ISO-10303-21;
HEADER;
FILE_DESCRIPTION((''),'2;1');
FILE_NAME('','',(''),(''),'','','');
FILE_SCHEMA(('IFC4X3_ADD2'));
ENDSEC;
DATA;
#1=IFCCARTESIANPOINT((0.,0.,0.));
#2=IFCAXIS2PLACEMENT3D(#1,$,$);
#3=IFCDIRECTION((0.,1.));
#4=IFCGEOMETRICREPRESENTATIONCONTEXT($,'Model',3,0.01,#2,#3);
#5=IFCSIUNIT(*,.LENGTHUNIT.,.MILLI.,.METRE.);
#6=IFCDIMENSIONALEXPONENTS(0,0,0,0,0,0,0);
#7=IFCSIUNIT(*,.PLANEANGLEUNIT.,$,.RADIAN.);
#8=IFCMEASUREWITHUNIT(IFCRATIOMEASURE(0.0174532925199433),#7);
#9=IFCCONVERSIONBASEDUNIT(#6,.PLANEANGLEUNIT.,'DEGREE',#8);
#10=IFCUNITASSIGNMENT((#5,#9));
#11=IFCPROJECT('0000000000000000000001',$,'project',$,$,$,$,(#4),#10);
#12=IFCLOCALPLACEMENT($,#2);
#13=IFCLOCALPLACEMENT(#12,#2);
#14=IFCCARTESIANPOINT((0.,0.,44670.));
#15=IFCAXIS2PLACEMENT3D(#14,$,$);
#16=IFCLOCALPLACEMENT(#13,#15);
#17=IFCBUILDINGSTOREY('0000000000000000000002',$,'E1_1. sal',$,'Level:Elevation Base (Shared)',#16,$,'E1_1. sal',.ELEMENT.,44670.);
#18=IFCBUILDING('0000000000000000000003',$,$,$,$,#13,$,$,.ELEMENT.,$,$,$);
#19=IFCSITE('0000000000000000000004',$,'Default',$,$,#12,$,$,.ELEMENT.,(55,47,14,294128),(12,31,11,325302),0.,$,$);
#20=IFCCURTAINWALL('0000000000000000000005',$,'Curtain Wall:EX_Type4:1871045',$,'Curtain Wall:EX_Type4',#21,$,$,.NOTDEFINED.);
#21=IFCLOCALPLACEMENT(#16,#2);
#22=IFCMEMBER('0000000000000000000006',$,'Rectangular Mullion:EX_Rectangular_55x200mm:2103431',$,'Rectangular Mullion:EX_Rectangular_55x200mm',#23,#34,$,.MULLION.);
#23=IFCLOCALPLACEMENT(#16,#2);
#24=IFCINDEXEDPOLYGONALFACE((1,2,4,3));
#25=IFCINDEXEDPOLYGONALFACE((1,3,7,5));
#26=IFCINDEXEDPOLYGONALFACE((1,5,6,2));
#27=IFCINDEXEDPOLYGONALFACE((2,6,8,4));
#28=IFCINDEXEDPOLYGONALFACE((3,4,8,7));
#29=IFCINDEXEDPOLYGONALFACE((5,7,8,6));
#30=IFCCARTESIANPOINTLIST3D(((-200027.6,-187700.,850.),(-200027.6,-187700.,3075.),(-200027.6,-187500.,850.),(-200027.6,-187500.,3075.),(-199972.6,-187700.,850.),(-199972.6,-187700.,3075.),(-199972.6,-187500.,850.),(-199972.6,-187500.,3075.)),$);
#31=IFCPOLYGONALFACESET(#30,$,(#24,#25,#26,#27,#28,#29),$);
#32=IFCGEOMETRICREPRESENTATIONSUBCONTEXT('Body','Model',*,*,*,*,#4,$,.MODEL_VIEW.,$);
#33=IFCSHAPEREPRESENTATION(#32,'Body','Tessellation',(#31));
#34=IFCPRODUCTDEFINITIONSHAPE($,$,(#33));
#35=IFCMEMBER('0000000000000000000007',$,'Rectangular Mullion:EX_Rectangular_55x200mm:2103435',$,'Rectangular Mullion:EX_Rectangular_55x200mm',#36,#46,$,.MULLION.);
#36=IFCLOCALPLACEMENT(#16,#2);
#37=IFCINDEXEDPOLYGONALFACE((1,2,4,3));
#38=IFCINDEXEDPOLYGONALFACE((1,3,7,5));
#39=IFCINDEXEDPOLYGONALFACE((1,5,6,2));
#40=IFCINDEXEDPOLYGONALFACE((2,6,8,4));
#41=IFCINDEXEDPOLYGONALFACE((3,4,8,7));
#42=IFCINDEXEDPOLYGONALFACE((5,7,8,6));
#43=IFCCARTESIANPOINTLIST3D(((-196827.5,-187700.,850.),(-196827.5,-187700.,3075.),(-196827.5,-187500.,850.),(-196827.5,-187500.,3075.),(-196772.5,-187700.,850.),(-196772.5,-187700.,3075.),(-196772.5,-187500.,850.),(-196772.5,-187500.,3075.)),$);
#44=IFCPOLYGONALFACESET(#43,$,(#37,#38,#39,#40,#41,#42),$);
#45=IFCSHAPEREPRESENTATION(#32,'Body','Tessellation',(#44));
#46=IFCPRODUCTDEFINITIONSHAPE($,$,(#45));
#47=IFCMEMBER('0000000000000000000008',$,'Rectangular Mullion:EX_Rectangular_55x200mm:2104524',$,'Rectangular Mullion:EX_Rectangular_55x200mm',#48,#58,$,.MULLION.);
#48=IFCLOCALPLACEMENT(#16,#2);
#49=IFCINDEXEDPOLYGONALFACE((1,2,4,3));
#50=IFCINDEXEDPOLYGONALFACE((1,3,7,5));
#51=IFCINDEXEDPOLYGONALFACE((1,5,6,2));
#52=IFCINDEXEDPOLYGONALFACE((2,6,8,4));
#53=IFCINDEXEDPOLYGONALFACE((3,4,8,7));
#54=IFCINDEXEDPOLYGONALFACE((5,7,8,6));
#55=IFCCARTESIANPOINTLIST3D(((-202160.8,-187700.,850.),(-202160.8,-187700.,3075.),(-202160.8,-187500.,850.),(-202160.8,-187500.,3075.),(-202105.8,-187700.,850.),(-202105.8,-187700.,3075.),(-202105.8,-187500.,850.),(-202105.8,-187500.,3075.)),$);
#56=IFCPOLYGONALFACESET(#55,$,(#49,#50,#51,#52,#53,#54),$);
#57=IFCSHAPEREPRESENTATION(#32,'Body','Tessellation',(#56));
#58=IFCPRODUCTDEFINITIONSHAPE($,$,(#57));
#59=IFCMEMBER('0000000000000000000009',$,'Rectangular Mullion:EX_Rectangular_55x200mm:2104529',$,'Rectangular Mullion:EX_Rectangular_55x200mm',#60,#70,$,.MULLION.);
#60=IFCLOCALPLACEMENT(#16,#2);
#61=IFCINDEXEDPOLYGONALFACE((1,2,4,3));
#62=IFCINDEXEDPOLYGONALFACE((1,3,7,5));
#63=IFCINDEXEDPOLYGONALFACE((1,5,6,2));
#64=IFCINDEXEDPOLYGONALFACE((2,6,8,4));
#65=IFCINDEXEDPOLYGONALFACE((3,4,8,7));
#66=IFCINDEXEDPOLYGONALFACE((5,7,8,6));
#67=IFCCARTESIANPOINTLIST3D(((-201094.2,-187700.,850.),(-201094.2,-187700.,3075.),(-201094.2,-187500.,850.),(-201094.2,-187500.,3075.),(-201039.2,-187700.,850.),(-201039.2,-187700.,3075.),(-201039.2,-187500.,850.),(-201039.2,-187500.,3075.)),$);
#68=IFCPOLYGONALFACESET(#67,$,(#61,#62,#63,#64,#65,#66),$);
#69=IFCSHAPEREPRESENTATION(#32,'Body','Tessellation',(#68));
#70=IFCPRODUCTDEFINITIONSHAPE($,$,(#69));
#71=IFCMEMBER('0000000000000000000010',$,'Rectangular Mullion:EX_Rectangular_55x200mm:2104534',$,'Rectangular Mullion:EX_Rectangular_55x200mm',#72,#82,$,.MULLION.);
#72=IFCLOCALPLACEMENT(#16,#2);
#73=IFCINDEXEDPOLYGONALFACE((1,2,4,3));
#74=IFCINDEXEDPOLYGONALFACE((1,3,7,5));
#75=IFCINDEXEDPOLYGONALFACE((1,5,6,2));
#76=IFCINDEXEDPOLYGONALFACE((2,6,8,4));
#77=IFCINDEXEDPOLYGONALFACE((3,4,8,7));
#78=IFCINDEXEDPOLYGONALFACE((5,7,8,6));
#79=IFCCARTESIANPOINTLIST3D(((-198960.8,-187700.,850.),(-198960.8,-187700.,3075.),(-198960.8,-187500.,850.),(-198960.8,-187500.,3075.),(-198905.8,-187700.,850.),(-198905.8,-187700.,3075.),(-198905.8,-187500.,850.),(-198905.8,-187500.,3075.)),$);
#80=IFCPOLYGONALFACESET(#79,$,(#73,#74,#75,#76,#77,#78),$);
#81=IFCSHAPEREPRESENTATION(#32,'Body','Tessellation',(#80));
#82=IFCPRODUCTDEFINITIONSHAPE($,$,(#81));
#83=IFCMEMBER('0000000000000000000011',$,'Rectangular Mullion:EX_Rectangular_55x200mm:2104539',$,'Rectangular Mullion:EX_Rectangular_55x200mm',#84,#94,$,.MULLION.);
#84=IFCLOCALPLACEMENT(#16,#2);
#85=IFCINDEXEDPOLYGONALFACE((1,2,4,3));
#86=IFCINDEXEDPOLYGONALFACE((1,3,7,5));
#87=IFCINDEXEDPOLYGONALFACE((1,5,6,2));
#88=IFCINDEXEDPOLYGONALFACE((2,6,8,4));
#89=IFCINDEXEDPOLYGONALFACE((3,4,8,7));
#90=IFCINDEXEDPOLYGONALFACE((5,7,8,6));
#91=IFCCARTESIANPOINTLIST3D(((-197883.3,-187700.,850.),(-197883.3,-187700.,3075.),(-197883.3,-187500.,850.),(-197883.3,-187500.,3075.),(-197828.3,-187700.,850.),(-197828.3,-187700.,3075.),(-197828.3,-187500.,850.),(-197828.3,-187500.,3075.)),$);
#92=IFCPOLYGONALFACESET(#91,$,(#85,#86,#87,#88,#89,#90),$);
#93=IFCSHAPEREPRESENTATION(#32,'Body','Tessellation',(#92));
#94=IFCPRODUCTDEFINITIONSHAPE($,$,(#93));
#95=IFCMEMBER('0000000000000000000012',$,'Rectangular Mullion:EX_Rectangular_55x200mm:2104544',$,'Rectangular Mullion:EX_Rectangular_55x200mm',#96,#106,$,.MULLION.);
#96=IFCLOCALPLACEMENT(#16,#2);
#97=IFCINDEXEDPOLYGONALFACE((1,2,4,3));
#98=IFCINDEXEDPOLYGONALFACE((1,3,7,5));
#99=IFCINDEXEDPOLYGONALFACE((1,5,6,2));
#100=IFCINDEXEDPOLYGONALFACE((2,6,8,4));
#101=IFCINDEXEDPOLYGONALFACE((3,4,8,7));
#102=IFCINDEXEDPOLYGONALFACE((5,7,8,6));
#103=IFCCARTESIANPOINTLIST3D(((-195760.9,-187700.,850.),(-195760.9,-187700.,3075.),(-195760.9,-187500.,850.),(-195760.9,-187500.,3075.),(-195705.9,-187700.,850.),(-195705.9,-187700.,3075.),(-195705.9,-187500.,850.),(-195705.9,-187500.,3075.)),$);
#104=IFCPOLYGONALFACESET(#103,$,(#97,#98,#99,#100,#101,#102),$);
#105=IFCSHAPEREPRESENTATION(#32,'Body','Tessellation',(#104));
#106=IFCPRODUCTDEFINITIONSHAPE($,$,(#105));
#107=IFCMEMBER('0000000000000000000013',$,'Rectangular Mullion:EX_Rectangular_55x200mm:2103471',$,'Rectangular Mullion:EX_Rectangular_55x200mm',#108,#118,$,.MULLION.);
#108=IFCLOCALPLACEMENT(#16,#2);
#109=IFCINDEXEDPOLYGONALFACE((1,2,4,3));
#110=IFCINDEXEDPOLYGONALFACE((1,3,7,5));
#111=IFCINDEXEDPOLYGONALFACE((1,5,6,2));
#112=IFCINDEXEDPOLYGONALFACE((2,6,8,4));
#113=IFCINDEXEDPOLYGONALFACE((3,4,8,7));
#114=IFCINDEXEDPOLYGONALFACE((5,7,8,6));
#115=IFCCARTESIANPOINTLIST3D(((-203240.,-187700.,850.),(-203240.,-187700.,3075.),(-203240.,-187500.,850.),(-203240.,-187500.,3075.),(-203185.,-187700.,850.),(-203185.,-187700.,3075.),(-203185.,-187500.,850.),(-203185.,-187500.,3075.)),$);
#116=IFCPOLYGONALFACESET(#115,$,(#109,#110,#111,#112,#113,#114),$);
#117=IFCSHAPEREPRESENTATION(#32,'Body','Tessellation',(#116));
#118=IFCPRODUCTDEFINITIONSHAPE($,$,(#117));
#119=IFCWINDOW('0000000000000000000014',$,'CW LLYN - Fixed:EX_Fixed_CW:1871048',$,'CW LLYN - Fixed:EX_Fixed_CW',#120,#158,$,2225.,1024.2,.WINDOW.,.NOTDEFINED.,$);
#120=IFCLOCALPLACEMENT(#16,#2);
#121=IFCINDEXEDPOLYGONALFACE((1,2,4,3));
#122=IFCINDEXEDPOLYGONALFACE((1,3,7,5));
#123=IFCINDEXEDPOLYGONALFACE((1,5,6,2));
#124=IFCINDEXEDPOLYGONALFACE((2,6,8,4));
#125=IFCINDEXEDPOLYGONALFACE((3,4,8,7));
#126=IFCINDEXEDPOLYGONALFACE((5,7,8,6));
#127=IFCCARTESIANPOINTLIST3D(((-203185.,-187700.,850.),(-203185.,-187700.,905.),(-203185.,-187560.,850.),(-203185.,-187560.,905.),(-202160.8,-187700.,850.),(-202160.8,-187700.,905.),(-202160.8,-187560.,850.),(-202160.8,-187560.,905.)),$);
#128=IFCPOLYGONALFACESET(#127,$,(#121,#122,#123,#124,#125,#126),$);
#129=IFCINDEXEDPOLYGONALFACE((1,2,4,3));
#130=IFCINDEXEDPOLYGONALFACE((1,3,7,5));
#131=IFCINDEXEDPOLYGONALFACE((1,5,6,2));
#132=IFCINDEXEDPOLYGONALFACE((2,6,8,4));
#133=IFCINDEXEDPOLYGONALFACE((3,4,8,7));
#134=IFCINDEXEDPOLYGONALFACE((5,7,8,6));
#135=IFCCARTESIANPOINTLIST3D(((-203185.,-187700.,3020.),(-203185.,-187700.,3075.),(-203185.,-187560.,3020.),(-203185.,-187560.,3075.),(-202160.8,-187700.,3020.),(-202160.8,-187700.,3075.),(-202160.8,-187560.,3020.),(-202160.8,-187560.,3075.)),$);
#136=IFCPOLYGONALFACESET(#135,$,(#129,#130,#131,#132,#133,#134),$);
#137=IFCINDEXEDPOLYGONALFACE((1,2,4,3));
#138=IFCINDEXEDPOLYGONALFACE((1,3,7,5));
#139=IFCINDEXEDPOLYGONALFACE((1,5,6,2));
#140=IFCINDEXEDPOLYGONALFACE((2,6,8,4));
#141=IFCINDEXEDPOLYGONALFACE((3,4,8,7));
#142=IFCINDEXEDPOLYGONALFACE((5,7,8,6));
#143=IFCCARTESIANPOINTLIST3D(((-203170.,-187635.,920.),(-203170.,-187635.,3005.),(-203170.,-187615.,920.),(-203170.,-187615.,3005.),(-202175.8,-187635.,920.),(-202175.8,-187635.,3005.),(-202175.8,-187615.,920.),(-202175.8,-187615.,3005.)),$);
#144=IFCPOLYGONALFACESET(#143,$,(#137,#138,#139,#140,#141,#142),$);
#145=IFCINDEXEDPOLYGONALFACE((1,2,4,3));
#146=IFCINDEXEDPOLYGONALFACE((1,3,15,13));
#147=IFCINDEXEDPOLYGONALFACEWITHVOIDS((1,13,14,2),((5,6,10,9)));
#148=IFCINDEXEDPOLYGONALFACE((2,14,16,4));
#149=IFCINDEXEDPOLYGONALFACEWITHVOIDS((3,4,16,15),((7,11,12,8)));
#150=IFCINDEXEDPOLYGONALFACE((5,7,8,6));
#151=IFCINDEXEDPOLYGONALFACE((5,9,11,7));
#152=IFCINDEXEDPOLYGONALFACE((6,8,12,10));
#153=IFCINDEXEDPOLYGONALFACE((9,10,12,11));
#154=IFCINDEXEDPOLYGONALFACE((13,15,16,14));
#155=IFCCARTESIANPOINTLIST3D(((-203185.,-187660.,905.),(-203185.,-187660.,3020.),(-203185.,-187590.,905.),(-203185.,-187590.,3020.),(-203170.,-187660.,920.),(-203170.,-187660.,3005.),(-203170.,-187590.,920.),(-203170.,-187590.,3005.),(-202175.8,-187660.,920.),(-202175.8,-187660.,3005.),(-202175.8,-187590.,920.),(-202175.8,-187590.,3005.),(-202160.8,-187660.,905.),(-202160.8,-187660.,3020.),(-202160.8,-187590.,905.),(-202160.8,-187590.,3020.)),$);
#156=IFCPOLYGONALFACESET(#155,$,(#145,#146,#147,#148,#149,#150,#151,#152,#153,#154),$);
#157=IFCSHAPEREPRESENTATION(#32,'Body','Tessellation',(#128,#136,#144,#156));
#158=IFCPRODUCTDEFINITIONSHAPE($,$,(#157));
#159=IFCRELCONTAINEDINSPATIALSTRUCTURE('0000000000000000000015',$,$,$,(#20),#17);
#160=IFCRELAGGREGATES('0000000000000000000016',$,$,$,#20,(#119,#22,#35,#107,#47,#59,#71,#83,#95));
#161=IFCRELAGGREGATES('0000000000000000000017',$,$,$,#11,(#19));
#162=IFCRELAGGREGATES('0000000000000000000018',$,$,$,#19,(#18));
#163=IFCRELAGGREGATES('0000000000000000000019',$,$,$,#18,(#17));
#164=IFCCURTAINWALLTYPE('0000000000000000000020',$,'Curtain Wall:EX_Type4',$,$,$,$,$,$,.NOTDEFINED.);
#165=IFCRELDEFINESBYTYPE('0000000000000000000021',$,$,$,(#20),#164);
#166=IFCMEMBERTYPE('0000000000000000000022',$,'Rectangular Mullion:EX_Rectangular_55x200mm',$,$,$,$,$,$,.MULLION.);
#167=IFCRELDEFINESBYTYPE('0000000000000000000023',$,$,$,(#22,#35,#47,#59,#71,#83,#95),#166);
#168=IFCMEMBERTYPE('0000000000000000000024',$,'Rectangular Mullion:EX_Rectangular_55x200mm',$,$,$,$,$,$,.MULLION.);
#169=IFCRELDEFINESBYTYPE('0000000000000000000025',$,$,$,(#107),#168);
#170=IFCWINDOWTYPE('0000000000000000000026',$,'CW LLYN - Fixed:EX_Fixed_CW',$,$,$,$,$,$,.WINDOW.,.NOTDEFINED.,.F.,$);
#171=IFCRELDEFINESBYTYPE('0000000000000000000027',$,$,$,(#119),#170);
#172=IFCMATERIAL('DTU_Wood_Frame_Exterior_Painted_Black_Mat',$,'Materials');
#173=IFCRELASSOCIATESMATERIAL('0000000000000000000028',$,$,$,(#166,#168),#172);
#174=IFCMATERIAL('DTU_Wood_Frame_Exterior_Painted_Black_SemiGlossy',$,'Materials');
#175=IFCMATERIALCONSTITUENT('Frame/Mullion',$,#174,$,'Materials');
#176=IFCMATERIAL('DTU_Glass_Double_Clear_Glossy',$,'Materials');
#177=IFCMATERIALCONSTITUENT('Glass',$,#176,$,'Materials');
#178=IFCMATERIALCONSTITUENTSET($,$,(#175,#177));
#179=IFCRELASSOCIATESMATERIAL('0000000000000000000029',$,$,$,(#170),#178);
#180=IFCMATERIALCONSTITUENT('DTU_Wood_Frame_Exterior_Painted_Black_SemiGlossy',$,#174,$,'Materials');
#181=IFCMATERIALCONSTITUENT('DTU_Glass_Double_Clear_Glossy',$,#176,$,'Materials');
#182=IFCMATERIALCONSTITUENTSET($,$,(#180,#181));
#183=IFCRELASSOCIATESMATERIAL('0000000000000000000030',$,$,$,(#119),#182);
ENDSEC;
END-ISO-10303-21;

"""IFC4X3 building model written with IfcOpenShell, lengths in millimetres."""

from ifc_helpers import new_model, entity, si_unit, converted_unit, direction, frame, frame_2d, origin, origin_2d_with_axis, place, context, subcontext, project, spatial, polyline, rectangle, outline, extrude, source, transform, mapped, material, constituent, constituent_set, material_profile, profile_set, type_object, type_shapes, element, aggregate, save


model = new_model("IFC4X3")

# Units and contexts
model_context = context("Model", 3, precision=0.01, world=origin(), true_north=direction((0.0, 1.0)))
body_context = subcontext(model_context, "Body", "Model", "MODEL_VIEW")
ifc_project = project(units=[si_unit("LENGTHUNIT", "METRE", prefix="MILLI"), converted_unit("PLANEANGLEUNIT", "DEGREE", entity("IfcRatioMeasure", 0.0174532925199433), si_unit("PLANEANGLEUNIT", "RADIAN"), dimensions=[0, 0, 0, 0, 0, 0, 0])], contexts=[model_context])

# Site, building, storey
site_placement = place(None, origin())
site = spatial("IfcSite", under=ifc_project, at=site_placement, Name="Default", CompositionType="ELEMENT", RefLatitude=(55, 47, 14, 294128), RefLongitude=(12, 31, 11, 325302), RefElevation=0.0)
building_placement = place(site_placement, origin())
building = spatial("IfcBuilding", under=site, at=building_placement, CompositionType="ELEMENT")
storey_placement = place(building_placement, frame((0.0, 0.0, 44670.0)))
storey = spatial("IfcBuildingStorey", under=building, at=storey_placement, Name="E1_1. sal", ObjectType="Level:Elevation Base (Shared)", LongName="E1_1. sal", CompositionType="ELEMENT", Elevation=44670.0)

# Curtain wall, members
curtain_wall_type_1 = type_object("IfcCurtainWallType", Name="Curtain Wall:EX_Type4", PredefinedType="NOTDEFINED")
curtain_wall_1_placement = place(storey_placement, frame((0.0, 0.0, -44670.0)))
curtain_wall_1 = element("IfcCurtainWall", 1, at=curtain_wall_1_placement, inside=storey, type_object=curtain_wall_type_1, Name="Curtain Wall:EX_Type4:1871045", ObjectType="Curtain Wall:EX_Type4", PredefinedType="NOTDEFINED")
ifc_material_1 = material(Name="DTU_Wood_Frame_Exterior_Painted_Black_Mat", Category="Materials")
ifc_material_profile = material_profile(ifc_material_1, rectangle(XDim=200.0, YDim=55.0, at=origin_2d_with_axis()), Name="EX_Rectangular_55x200mm")
ifc_profile_set = profile_set([ifc_material_profile], Name="EX_Rectangular_55x200mm")
member_type_1 = type_object("IfcMemberType", Name="Rectangular Mullion:EX_Rectangular_55x200mm", PredefinedType="MULLION", material=ifc_profile_set)
shared_shape_1 = source(origin(), body_context, "Body", "SweptSolid", [
    extrude(rectangle(XDim=200.0, YDim=55.0, at=origin_2d_with_axis()), frame((0.0, -100.0, -2225.0), z_axis=(0.0, 0.0, 1.0), x_axis=(0.0, -1.0, 0.0)), (0.0, 0.0, 1.0), 2225.0),
])
type_shapes(member_type_1, [shared_shape_1])
member_1_placement = place(curtain_wall_1_placement, frame((-200000.1, -187500.0, 45520.0), z_axis=(0.0, 0.0, -1.0), x_axis=(-1.0, 0.0, 0.0)))
member_1 = element("IfcMember", 2, at=member_1_placement, type_object=member_type_1, Name="Rectangular Mullion:EX_Rectangular_55x200mm:2103431", ObjectType="Rectangular Mullion:EX_Rectangular_55x200mm", PredefinedType="MULLION", context=body_context, shape_type="MappedRepresentation", body=[
    mapped(shared_shape_1, transform((0.0, 0.0, 0.0), scale=1.0)),
])
member_2_placement = place(curtain_wall_1_placement, frame((-196800.0, -187500.0, 45520.0), z_axis=(0.0, 0.0, -1.0), x_axis=(-1.0, 0.0, 0.0)))
member_2 = element("IfcMember", 3, at=member_2_placement, type_object=member_type_1, Name="Rectangular Mullion:EX_Rectangular_55x200mm:2103435", ObjectType="Rectangular Mullion:EX_Rectangular_55x200mm", PredefinedType="MULLION", context=body_context, shape_type="MappedRepresentation", body=[
    mapped(shared_shape_1, transform((0.0, 0.0, 0.0), scale=1.0)),
])
member_3_placement = place(curtain_wall_1_placement, frame((-202133.3, -187500.0, 45520.0), z_axis=(0.0, 0.0, -1.0), x_axis=(-1.0, 0.0, 0.0)))
member_3 = element("IfcMember", 4, at=member_3_placement, type_object=member_type_1, Name="Rectangular Mullion:EX_Rectangular_55x200mm:2104524", ObjectType="Rectangular Mullion:EX_Rectangular_55x200mm", PredefinedType="MULLION", context=body_context, shape_type="MappedRepresentation", body=[
    mapped(shared_shape_1, transform((0.0, 0.0, 0.0), scale=1.0)),
])
member_4_placement = place(curtain_wall_1_placement, frame((-201066.7, -187500.0, 45520.0), z_axis=(0.0, 0.0, -1.0), x_axis=(-1.0, 0.0, 0.0)))
member_4 = element("IfcMember", 5, at=member_4_placement, type_object=member_type_1, Name="Rectangular Mullion:EX_Rectangular_55x200mm:2104529", ObjectType="Rectangular Mullion:EX_Rectangular_55x200mm", PredefinedType="MULLION", context=body_context, shape_type="MappedRepresentation", body=[
    mapped(shared_shape_1, transform((0.0, 0.0, 0.0), scale=1.0)),
])
member_5_placement = place(curtain_wall_1_placement, frame((-198933.3, -187500.0, 45520.0), z_axis=(0.0, 0.0, -1.0), x_axis=(-1.0, 0.0, 0.0)))
member_5 = element("IfcMember", 6, at=member_5_placement, type_object=member_type_1, Name="Rectangular Mullion:EX_Rectangular_55x200mm:2104534", ObjectType="Rectangular Mullion:EX_Rectangular_55x200mm", PredefinedType="MULLION", context=body_context, shape_type="MappedRepresentation", body=[
    mapped(shared_shape_1, transform((0.0, 0.0, 0.0), scale=1.0)),
])
member_6_placement = place(curtain_wall_1_placement, frame((-197855.8, -187500.0, 45520.0), z_axis=(0.0, 0.0, -1.0), x_axis=(-1.0, 0.0, 0.0)))
member_6 = element("IfcMember", 7, at=member_6_placement, type_object=member_type_1, Name="Rectangular Mullion:EX_Rectangular_55x200mm:2104539", ObjectType="Rectangular Mullion:EX_Rectangular_55x200mm", PredefinedType="MULLION", context=body_context, shape_type="MappedRepresentation", body=[
    mapped(shared_shape_1, transform((0.0, 0.0, 0.0), scale=1.0)),
])
member_7_placement = place(curtain_wall_1_placement, frame((-195733.4, -187500.0, 45520.0), z_axis=(0.0, 0.0, -1.0), x_axis=(-1.0, 0.0, 0.0)))
member_7 = element("IfcMember", 8, at=member_7_placement, type_object=member_type_1, Name="Rectangular Mullion:EX_Rectangular_55x200mm:2104544", ObjectType="Rectangular Mullion:EX_Rectangular_55x200mm", PredefinedType="MULLION", context=body_context, shape_type="MappedRepresentation", body=[
    mapped(shared_shape_1, transform((0.0, 0.0, 0.0), scale=1.0)),
])
member_type_2 = type_object("IfcMemberType", Name="Rectangular Mullion:EX_Rectangular_55x200mm", PredefinedType="MULLION", material=ifc_profile_set)
shared_shape_2 = source(origin(), body_context, "Body", "SweptSolid", [
    extrude(rectangle(XDim=200.0, YDim=55.0, at=origin_2d_with_axis()), frame((-27.5, -100.0, -2225.0), z_axis=(0.0, 0.0, 1.0), x_axis=(0.0, -1.0, 0.0)), (0.0, 0.0, 1.0), 2225.0),
])
type_shapes(member_type_2, [shared_shape_2])
member_8_placement = place(curtain_wall_1_placement, frame((-203240.0, -187500.0, 45520.0), z_axis=(0.0, 0.0, -1.0), x_axis=(-1.0, 0.0, 0.0)))
member_8 = element("IfcMember", 9, at=member_8_placement, type_object=member_type_2, Name="Rectangular Mullion:EX_Rectangular_55x200mm:2103471", ObjectType="Rectangular Mullion:EX_Rectangular_55x200mm", PredefinedType="MULLION", context=body_context, shape_type="MappedRepresentation", body=[
    mapped(shared_shape_2, transform((0.0, 0.0, 0.0), scale=1.0)),
])

# Window
ifc_material_2 = material(Name="DTU_Wood_Frame_Exterior_Painted_Black_SemiGlossy", Category="Materials")
ifc_constituent_1 = constituent(ifc_material_2, Name="DTU_Wood_Frame_Exterior_Painted_Black_SemiGlossy", Category="Materials")
ifc_material_3 = material(Name="DTU_Glass_Double_Clear_Glossy", Category="Materials")
ifc_constituent_2 = constituent(ifc_material_3, Name="DTU_Glass_Double_Clear_Glossy", Category="Materials")
ifc_constituent_set_1 = constituent_set(constituents=[ifc_constituent_1, ifc_constituent_2])
ifc_constituent_3 = constituent(ifc_material_2, Name="Frame/Mullion", Category="Materials")
ifc_constituent_4 = constituent(ifc_material_3, Name="Glass", Category="Materials")
ifc_constituent_set_2 = constituent_set(constituents=[ifc_constituent_3, ifc_constituent_4])
window_type_1 = type_object("IfcWindowType", Name="CW LLYN - Fixed:EX_Fixed_CW", ParameterTakesPrecedence=False, PartitioningType="NOTDEFINED", PredefinedType="WINDOW", material=ifc_constituent_set_2)
shared_shape_3 = source(origin(), body_context, "Body", "SweptSolid", [
    extrude(rectangle(XDim=140.0, YDim=1024.2, at=origin_2d_with_axis()), frame((0.0, -130.0, 0.0), z_axis=(0.0, 0.0, 1.0), x_axis=(0.0, -1.0, 0.0)), (0.0, 0.0, 1.0), 55.0),
    extrude(rectangle(XDim=140.0, YDim=1024.2, at=frame_2d((0.0, 0.0), x_axis=(1.0, 0.0))), frame((0.0, -130.0, 2170.0), z_axis=(0.0, 0.0, 1.0), x_axis=(0.0, -1.0, 0.0)), (0.0, 0.0, 1.0), 55.0),
    extrude(rectangle(XDim=994.2, YDim=20.0, at=frame_2d((0.0, 0.0), x_axis=(1.0, 0.0))), frame((0.0, -125.0, 70.0), z_axis=(0.0, 0.0, 1.0), x_axis=(-1.0, 0.0, 0.0)), (0.0, 0.0, 1.0), 2085.0),
    extrude(outline(polyline([(-1057.5, -512.1), (1057.5, -512.1), (1057.5, 512.1), (-1057.5, 512.1), (-1057.5, -512.1)]), holes=[polyline([(-1042.5, 497.1), (1042.5, 497.1), (1042.5, -497.1), (-1042.5, -497.1), (-1042.5, 497.1)])]), frame((0.0, -90.0, 1112.5), z_axis=(0.0, -1.0, 0.0), x_axis=(0.0, 0.0, 1.0)), (0.0, 0.0, 1.0), 70.0),
])
type_shapes(window_type_1, [shared_shape_3])
window_1_placement = place(curtain_wall_1_placement, frame((-202672.9, -187500.0, 45520.0)))
window_1 = element("IfcWindow", 10, at=window_1_placement, type_object=window_type_1, material=ifc_constituent_set_1, Name="CW LLYN - Fixed:EX_Fixed_CW:1871048", ObjectType="CW LLYN - Fixed:EX_Fixed_CW", OverallHeight=2225.0, OverallWidth=1024.2, PartitioningType="NOTDEFINED", PredefinedType="WINDOW", context=body_context, shape_type="MappedRepresentation", body=[
    mapped(shared_shape_3, transform((0.0, 0.0, 0.0), scale=1.0)),
])

aggregate(curtain_wall_1, [window_1, member_1, member_2, member_8, member_3, member_4, member_5, member_6, member_7])

save(model, "model.ifc")
